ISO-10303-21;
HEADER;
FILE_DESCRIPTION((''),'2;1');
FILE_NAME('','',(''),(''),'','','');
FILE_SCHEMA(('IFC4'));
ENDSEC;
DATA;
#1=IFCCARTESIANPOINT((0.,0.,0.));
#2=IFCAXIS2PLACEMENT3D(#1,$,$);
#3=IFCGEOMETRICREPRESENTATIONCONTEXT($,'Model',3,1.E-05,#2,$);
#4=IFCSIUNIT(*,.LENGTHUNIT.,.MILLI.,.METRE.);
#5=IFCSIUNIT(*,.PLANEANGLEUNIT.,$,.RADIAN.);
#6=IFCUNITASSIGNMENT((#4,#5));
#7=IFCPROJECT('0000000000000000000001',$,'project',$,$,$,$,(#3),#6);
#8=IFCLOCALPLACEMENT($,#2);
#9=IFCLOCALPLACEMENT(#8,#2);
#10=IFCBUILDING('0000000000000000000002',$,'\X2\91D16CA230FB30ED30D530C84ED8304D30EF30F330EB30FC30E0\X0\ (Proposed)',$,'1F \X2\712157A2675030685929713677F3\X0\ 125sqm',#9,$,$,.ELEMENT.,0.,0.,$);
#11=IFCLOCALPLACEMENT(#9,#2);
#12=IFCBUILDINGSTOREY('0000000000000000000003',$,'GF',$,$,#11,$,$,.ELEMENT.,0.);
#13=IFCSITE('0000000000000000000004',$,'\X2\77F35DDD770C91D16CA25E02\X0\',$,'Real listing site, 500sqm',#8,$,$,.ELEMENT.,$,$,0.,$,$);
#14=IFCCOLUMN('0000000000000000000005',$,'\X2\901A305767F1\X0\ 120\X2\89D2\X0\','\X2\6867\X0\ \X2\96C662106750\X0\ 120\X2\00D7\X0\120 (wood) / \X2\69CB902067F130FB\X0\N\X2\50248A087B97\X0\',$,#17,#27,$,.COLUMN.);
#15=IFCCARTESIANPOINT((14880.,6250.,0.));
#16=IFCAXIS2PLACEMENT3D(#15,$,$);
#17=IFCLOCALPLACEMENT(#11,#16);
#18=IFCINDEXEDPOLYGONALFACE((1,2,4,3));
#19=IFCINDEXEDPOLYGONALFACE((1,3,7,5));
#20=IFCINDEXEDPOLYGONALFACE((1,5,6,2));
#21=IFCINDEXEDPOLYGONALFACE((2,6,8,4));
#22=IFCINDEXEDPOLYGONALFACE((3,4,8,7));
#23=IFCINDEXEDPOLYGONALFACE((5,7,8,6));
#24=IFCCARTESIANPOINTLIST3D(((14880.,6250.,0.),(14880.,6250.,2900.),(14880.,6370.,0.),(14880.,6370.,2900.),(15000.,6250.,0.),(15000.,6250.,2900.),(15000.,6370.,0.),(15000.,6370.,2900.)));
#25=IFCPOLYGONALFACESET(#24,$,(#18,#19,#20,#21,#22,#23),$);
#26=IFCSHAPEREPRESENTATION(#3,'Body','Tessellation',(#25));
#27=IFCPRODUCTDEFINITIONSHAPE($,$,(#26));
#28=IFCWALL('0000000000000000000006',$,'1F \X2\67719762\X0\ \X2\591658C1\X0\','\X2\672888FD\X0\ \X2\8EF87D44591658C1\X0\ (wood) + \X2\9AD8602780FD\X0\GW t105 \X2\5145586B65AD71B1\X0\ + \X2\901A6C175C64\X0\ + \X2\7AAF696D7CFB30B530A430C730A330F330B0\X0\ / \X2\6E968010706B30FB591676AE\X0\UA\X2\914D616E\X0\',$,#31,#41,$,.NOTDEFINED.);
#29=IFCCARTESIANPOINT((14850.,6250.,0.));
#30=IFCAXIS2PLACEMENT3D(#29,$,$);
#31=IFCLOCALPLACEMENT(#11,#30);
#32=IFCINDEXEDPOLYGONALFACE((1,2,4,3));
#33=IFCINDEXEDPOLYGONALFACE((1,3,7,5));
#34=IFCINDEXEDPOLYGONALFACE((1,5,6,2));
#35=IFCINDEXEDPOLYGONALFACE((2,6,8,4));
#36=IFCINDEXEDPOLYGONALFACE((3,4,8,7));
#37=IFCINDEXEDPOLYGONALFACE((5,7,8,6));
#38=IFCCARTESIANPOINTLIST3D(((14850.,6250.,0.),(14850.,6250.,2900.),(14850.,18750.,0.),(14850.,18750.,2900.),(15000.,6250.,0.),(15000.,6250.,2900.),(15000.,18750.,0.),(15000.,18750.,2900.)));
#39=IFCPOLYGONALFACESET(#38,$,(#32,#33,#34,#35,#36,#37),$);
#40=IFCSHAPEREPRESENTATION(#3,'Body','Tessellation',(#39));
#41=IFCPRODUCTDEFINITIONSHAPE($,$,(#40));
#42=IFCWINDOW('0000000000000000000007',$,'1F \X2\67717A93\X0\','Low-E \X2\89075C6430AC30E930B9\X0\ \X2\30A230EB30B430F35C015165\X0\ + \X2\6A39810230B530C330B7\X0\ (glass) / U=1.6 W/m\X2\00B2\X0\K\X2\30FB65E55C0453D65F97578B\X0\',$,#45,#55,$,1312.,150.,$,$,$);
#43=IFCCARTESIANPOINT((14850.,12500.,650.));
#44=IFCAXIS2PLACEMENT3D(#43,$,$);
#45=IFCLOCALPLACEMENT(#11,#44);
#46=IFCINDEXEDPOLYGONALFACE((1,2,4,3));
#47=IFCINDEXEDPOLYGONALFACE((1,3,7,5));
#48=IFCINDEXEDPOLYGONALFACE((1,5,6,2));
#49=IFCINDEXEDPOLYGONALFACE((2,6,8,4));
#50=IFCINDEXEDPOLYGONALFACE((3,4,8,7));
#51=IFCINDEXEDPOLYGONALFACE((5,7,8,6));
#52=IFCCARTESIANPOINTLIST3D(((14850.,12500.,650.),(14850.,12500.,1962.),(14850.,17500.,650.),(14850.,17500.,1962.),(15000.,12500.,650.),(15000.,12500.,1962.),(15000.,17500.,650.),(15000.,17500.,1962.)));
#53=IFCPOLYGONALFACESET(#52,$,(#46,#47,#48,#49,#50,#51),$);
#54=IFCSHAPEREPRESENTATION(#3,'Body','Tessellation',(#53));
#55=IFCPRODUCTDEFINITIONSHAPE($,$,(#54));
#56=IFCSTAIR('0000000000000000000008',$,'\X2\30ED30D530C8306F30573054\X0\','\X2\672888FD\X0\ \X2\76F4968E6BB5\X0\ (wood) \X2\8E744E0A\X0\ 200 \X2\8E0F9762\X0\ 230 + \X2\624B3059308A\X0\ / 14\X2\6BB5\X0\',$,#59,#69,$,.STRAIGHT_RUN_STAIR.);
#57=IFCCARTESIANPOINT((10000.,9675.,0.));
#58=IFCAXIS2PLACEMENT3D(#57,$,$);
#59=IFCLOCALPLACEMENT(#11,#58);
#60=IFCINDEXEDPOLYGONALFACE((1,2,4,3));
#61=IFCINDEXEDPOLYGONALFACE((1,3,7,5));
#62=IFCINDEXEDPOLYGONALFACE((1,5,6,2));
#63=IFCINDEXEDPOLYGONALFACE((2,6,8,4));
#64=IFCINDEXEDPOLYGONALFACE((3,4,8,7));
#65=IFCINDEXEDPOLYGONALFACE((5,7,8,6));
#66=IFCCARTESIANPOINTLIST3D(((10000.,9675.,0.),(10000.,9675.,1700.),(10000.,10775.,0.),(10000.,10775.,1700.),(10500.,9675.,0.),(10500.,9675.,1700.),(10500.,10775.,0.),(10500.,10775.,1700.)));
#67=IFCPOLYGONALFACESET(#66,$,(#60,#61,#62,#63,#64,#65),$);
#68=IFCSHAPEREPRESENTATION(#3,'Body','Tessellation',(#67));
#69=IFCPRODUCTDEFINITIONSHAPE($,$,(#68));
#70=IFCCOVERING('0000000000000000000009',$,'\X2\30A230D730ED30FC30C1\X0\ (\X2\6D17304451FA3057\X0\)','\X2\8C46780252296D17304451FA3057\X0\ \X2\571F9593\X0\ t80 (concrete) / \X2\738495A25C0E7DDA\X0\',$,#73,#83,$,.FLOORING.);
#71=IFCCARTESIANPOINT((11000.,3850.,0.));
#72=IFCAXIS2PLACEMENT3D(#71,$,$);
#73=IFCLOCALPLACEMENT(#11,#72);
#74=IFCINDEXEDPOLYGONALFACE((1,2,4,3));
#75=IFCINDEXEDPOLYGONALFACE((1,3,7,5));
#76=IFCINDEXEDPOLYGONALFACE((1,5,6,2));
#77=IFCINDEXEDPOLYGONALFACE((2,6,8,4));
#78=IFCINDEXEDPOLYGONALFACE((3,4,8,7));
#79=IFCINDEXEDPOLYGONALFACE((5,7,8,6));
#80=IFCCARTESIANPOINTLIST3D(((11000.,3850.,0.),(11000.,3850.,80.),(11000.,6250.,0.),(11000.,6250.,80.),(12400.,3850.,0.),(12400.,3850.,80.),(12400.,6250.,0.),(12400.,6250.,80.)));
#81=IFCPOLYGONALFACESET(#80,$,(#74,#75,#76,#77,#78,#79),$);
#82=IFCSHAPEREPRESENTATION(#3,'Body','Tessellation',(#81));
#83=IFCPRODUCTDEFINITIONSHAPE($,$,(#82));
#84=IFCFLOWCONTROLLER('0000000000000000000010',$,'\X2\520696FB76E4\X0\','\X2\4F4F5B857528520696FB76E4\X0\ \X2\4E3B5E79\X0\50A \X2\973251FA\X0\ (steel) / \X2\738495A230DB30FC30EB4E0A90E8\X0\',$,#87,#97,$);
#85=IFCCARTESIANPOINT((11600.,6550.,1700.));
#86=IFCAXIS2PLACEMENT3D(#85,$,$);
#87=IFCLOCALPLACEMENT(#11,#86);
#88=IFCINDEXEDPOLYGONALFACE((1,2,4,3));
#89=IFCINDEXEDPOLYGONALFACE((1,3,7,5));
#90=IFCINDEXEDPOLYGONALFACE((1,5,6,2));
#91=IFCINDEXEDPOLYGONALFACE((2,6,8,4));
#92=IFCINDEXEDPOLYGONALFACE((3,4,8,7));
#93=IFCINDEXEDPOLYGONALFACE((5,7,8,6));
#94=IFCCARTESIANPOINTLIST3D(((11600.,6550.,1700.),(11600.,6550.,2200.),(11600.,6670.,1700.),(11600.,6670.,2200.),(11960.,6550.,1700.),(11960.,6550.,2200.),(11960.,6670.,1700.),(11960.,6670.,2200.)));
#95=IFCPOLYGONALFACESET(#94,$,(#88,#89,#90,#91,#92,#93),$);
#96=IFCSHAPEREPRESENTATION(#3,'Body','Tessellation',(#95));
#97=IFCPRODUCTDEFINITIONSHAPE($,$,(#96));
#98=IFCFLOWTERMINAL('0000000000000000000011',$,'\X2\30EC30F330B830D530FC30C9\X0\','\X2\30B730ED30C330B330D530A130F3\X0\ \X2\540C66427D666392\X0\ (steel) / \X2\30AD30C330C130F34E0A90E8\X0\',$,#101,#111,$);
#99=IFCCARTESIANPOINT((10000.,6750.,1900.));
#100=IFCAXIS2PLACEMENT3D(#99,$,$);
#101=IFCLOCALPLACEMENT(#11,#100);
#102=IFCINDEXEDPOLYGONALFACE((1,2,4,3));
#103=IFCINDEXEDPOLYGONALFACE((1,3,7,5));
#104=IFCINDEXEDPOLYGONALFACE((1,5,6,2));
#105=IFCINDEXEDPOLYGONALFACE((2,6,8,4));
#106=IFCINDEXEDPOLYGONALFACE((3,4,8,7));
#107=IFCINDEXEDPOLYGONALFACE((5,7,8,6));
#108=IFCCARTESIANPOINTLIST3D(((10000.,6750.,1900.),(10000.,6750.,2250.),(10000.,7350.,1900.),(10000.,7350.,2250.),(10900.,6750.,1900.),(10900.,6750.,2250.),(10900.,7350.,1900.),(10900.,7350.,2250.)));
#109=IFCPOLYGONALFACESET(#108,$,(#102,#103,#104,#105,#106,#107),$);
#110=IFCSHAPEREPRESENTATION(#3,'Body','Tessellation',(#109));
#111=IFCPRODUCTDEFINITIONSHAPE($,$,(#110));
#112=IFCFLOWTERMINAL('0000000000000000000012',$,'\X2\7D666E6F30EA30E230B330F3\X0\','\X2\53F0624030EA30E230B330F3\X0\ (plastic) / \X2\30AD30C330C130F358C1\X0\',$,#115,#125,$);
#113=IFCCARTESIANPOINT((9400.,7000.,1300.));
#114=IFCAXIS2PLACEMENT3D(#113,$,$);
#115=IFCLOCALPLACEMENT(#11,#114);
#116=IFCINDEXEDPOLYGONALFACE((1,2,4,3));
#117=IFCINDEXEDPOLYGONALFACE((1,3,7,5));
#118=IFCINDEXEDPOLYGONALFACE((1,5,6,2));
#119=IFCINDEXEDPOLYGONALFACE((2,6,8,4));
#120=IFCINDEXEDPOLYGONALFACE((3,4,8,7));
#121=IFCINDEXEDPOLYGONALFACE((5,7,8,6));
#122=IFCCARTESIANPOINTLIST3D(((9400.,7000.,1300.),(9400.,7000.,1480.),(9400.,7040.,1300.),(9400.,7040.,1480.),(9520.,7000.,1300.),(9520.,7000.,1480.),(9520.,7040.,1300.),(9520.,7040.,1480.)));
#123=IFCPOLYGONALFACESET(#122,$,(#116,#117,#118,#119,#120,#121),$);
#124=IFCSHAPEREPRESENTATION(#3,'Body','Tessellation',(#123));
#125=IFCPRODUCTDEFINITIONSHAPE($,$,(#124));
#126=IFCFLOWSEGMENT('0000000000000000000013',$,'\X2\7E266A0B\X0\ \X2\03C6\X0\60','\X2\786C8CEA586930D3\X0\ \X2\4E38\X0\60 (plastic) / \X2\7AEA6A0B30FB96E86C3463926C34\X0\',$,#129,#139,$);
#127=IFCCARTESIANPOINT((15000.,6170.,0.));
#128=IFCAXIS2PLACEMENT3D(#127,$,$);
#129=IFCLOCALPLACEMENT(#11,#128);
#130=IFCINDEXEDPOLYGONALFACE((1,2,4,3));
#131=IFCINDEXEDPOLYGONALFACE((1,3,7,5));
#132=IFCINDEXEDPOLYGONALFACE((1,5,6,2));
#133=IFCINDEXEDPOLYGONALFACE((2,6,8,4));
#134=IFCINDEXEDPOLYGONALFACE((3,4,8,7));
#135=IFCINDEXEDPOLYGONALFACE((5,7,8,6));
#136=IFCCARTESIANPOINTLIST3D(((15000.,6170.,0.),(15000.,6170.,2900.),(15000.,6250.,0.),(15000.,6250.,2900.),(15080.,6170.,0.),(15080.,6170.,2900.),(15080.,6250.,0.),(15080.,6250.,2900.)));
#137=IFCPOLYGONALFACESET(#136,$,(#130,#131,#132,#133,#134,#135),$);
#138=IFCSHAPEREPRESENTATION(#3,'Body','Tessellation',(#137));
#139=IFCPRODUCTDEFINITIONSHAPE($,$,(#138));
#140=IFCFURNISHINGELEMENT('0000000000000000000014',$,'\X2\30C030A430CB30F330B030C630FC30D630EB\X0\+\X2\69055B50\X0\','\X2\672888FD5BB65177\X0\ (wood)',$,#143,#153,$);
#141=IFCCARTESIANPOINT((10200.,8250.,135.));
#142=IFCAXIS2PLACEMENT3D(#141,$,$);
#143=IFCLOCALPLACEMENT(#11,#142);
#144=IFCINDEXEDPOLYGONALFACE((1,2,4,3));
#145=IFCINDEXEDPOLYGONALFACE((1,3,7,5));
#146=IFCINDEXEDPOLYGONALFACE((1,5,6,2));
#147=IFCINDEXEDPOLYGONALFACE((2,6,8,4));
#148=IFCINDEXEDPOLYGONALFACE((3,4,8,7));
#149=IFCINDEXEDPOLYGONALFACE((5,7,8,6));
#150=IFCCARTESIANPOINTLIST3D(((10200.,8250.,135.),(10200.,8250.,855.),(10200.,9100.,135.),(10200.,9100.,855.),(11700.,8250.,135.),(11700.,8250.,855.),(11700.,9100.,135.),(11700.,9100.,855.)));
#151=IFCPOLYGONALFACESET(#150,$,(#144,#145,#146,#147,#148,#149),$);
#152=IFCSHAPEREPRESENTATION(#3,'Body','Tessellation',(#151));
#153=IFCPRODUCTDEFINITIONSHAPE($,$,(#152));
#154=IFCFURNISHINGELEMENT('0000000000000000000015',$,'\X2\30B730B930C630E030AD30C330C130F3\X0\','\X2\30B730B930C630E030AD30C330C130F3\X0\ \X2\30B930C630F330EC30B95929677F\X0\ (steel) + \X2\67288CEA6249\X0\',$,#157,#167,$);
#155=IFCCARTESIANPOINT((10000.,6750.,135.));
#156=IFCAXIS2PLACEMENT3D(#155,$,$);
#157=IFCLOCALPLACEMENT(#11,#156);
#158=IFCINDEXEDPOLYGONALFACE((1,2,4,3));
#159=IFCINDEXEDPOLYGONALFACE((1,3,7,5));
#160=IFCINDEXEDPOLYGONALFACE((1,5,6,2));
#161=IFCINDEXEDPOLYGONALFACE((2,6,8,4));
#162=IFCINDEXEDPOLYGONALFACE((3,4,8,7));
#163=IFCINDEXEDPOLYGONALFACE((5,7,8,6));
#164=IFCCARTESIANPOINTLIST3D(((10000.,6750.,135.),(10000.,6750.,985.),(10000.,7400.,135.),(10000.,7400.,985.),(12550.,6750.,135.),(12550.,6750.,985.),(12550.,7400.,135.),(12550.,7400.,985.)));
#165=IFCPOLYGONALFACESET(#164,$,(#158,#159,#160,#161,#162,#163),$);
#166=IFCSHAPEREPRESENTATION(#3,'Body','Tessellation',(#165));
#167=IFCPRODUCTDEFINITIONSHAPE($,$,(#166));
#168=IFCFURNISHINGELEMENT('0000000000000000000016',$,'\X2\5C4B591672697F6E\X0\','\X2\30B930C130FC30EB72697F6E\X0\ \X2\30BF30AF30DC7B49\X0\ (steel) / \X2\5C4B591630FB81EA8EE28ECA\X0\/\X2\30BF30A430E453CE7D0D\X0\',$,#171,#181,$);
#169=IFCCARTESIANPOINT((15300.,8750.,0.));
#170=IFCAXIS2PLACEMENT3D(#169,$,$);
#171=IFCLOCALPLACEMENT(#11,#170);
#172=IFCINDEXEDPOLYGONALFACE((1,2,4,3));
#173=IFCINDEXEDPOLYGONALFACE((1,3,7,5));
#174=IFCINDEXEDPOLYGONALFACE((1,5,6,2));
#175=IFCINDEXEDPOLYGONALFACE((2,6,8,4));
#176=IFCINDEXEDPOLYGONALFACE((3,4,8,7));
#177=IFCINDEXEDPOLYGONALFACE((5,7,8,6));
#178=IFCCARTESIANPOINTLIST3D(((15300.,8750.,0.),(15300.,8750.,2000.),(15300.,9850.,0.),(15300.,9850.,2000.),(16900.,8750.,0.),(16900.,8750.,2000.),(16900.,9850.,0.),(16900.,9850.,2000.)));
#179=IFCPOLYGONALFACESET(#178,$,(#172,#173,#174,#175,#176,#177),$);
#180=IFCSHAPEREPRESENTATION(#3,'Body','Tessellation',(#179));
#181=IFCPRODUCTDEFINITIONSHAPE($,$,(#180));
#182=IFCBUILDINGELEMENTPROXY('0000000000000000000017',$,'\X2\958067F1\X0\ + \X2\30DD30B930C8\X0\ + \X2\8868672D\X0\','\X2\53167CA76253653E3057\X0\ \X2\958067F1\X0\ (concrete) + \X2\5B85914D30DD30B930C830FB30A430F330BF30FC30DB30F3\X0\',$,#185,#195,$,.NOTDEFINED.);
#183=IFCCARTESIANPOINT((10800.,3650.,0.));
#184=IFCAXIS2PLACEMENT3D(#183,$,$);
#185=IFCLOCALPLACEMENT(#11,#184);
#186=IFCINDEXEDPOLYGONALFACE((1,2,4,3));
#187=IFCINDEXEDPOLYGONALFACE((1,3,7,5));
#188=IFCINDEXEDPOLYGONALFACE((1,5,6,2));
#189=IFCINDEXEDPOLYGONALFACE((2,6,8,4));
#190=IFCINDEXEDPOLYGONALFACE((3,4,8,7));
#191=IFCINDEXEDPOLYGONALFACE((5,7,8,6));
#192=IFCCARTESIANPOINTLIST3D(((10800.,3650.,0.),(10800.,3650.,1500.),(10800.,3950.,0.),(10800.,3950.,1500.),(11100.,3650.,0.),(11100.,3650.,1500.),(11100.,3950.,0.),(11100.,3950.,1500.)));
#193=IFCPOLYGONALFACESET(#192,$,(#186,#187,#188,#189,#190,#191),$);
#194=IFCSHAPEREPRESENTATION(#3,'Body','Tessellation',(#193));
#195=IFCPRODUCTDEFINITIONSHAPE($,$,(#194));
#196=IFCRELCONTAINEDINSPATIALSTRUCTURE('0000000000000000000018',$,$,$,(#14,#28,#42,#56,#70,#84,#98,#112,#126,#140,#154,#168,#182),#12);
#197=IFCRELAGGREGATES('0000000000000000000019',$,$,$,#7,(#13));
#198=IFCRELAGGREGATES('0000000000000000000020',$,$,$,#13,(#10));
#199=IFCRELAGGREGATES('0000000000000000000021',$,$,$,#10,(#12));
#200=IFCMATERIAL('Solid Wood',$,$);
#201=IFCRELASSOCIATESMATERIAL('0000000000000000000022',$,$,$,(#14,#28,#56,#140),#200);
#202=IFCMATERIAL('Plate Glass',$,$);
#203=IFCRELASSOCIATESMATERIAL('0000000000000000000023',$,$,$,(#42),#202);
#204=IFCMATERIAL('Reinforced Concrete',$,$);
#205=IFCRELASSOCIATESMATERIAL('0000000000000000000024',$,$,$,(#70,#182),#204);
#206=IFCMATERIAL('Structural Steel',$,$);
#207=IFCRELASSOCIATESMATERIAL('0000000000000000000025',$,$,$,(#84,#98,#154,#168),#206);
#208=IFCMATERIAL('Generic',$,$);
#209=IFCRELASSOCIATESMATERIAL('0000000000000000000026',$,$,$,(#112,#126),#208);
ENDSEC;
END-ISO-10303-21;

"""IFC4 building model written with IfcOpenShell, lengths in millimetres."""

from ifc_helpers import new_model, si_unit, frame, frame_2d, origin, place, context, project, spatial, rectangle, extrude, material, element, fill, save


model = new_model("IFC4")

# Units and contexts
model_context = context("Model", 3, precision=1e-05, world=origin())
ifc_project = project(units=[si_unit("LENGTHUNIT", "METRE", prefix="MILLI"), si_unit("PLANEANGLEUNIT", "RADIAN")], contexts=[model_context])

# Site, building, storey
site_placement = place(None, origin())
site = spatial("IfcSite", under=ifc_project, at=site_placement, Name="石川県金沢市", ObjectType="Real listing site, 500sqm", CompositionType="ELEMENT", RefElevation=0.0)
building_placement = place(site_placement, origin())
building = spatial("IfcBuilding", under=site, at=building_placement, Name="金沢・ロフト付きワンルーム (Proposed)", ObjectType="1F 無垢材と天然石 125sqm", CompositionType="ELEMENT", ElevationOfRefHeight=0.0, ElevationOfTerrain=0.0)
storey_placement = place(building_placement, origin())
storey = spatial("IfcBuildingStorey", under=building, at=storey_placement, Name="GF", CompositionType="ELEMENT", Elevation=0.0)

# Column
ifc_material_1 = material(Name="Solid Wood")
column_1_placement = place(storey_placement, frame((14880.0, 6250.0, 0.0)))
element("IfcColumn", 1, at=column_1_placement, inside=storey, material=ifc_material_1, Name="通し柱 120角", Description="桧 集成材 120×120 (wood) / 構造柱・N値計算", PredefinedType="COLUMN", context=model_context, shape_type="SweptSolid", body=[
    extrude(rectangle(XDim=120.0, YDim=120.0, at=frame_2d((60.0, 60.0))), frame((14880.0, 6250.0, 0.0)), (0.0, 0.0, 1.0), 2900.0),
])

# Wall, opening, window
wall_1_placement = place(storey_placement, frame((14850.0, 6250.0, 0.0)))
wall_1 = element("IfcWall", 2, at=wall_1_placement, inside=storey, material=ifc_material_1, Name="1F 東面 外壁", Description="木製 軸組外壁 (wood) + 高性能GW t105 充填断熱 + 通気層 + 窯業系サイディング / 準耐火・外皮UA配慮", PredefinedType="NOTDEFINED", context=model_context, shape_type="SweptSolid", body=[
    extrude(rectangle(XDim=150.0, YDim=12500.0, at=frame_2d((75.0, 6250.0))), frame((14850.0, 6250.0, 0.0)), (0.0, 0.0, 1.0), 2900.0),
])
opening_placement = place(storey_placement, frame((14850.0, 12500.0, 650.0)))
opening = element("IfcOpeningElement", 3, at=opening_placement, cuts=wall_1, PredefinedType="NOTDEFINED", context=model_context, shape_type="SweptSolid", body=[
    extrude(rectangle(XDim=150.0, YDim=5000.0, at=frame_2d((75.0, 2500.0))), frame((14850.0, 12500.0, 650.0)), (0.0, 0.0, 1.0), 1312.0),
])
ifc_material_2 = material(Name="Plate Glass")
window_placement = place(storey_placement, frame((14850.0, 12500.0, 650.0)))
window = element("IfcWindow", 4, at=window_placement, inside=storey, material=ifc_material_2, Name="1F 東窓", Description="Low-E 複層ガラス アルゴン封入 + 樹脂サッシ (glass) / U=1.6 W/m²K・日射取得型", OverallHeight=1312.0, OverallWidth=150.0, context=model_context, shape_type="SweptSolid", body=[
    extrude(rectangle(XDim=150.0, YDim=5000.0, at=frame_2d((75.0, 2500.0))), frame((14850.0, 12500.0, 650.0)), (0.0, 0.0, 1.0), 1312.0),
])
fill(opening, window)

# Stair
stair_placement = place(storey_placement, frame((10000.0, 9675.0, 0.0)))
element("IfcStair", 5, at=stair_placement, inside=storey, material=ifc_material_1, Name="ロフトはしご", Description="木製 直階段 (wood) 蹴上 200 踏面 230 + 手すり / 14段", PredefinedType="STRAIGHT_RUN_STAIR", context=model_context, shape_type="SweptSolid", body=[
    extrude(rectangle(XDim=500.0, YDim=1100.0, at=frame_2d((250.0, 550.0))), frame((10000.0, 9675.0, 0.0)), (0.0, 0.0, 1.0), 1700.0),
])

# Covering
ifc_material_3 = material(Name="Reinforced Concrete")
covering_placement = place(storey_placement, frame((11000.0, 3850.0, 0.0)))
element("IfcCovering", 6, at=covering_placement, inside=storey, material=ifc_material_3, Name="アプローチ (洗い出し)", Description="豆砂利洗い出し 土間 t80 (concrete) / 玄関導線", PredefinedType="FLOORING", context=model_context, shape_type="SweptSolid", body=[
    extrude(rectangle(XDim=1400.0, YDim=2400.0, at=frame_2d((700.0, 1200.0))), frame((11000.0, 3850.0, 0.0)), (0.0, 0.0, 1.0), 80.0),
])

# Flow controller
ifc_material_4 = material(Name="Structural Steel")
flow_controller_placement = place(storey_placement, frame((11600.0, 6550.0, 1700.0)))
element("IfcFlowController", 7, at=flow_controller_placement, inside=storey, material=ifc_material_4, Name="分電盤", Description="住宅用分電盤 主幹50A 露出 (steel) / 玄関ホール上部", context=model_context, shape_type="SweptSolid", body=[
    extrude(rectangle(XDim=360.0, YDim=120.0, at=frame_2d((180.0, 60.0))), frame((11600.0, 6550.0, 1700.0)), (0.0, 0.0, 1.0), 500.0),
])

# Flow terminals
flow_terminal_1_placement = place(storey_placement, frame((10000.0, 6750.0, 1900.0)))
element("IfcFlowTerminal", 8, at=flow_terminal_1_placement, inside=storey, material=ifc_material_4, Name="レンジフード", Description="シロッコファン 同時給排 (steel) / キッチン上部", context=model_context, shape_type="SweptSolid", body=[
    extrude(rectangle(XDim=900.0, YDim=600.0, at=frame_2d((450.0, 300.0))), frame((10000.0, 6750.0, 1900.0)), (0.0, 0.0, 1.0), 350.0),
])
ifc_material_5 = material(Name="Generic")
flow_terminal_2_placement = place(storey_placement, frame((9400.0, 7000.0, 1300.0)))
element("IfcFlowTerminal", 9, at=flow_terminal_2_placement, inside=storey, material=ifc_material_5, Name="給湯リモコン", Description="台所リモコン (plastic) / キッチン壁", context=model_context, shape_type="SweptSolid", body=[
    extrude(rectangle(XDim=120.0, YDim=40.0, at=frame_2d((60.0, 20.0))), frame((9400.0, 7000.0, 1300.0)), (0.0, 0.0, 1.0), 180.0),
])

# Flow segment
flow_segment_placement = place(storey_placement, frame((15000.0, 6170.0, 0.0)))
element("IfcFlowSegment", 10, at=flow_segment_placement, inside=storey, material=ifc_material_5, Name="縦樋 φ60", Description="硬質塩ビ 丸60 (plastic) / 竪樋・雨水排水", context=model_context, shape_type="SweptSolid", body=[
    extrude(rectangle(XDim=80.0, YDim=80.0, at=frame_2d((40.0, 40.0))), frame((15000.0, 6170.0, 0.0)), (0.0, 0.0, 1.0), 2900.0),
])

# Furnishing elements
furnishing_1_placement = place(storey_placement, frame((10200.0, 8250.0, 135.0)))
element("IfcFurnishingElement", 11, at=furnishing_1_placement, inside=storey, material=ifc_material_1, Name="ダイニングテーブル+椅子", Description="木製家具 (wood)", context=model_context, shape_type="SweptSolid", body=[
    extrude(rectangle(XDim=1500.0, YDim=850.0, at=frame_2d((750.0, 425.0))), frame((10200.0, 8250.0, 135.0)), (0.0, 0.0, 1.0), 720.0),
])
furnishing_2_placement = place(storey_placement, frame((10000.0, 6750.0, 135.0)))
element("IfcFurnishingElement", 12, at=furnishing_2_placement, inside=storey, material=ifc_material_4, Name="システムキッチン", Description="システムキッチン ステンレス天板 (steel) + 木質扉", context=model_context, shape_type="SweptSolid", body=[
    extrude(rectangle(XDim=2550.0, YDim=650.0, at=frame_2d((1275.0, 325.0))), frame((10000.0, 6750.0, 135.0)), (0.0, 0.0, 1.0), 850.0),
])
furnishing_3_placement = place(storey_placement, frame((15300.0, 8750.0, 0.0)))
element("IfcFurnishingElement", 13, at=furnishing_3_placement, inside=storey, material=ifc_material_4, Name="屋外物置", Description="スチール物置 タクボ等 (steel) / 屋外・自転車/タイヤ収納", context=model_context, shape_type="SweptSolid", body=[
    extrude(rectangle(XDim=1600.0, YDim=1100.0, at=frame_2d((800.0, 550.0))), frame((15300.0, 8750.0, 0.0)), (0.0, 0.0, 1.0), 2000.0),
])

# Building element proxy
proxy_placement = place(storey_placement, frame((10800.0, 3650.0, 0.0)))
element("IfcBuildingElementProxy", 14, at=proxy_placement, inside=storey, material=ifc_material_3, Name="門柱 + ポスト + 表札", Description="化粧打放し 門柱 (concrete) + 宅配ポスト・インターホン", PredefinedType="NOTDEFINED", context=model_context, shape_type="SweptSolid", body=[
    extrude(rectangle(XDim=300.0, YDim=300.0, at=frame_2d((150.0, 150.0))), frame((10800.0, 3650.0, 0.0)), (0.0, 0.0, 1.0), 1500.0),
])

save(model, "model.ifc")
